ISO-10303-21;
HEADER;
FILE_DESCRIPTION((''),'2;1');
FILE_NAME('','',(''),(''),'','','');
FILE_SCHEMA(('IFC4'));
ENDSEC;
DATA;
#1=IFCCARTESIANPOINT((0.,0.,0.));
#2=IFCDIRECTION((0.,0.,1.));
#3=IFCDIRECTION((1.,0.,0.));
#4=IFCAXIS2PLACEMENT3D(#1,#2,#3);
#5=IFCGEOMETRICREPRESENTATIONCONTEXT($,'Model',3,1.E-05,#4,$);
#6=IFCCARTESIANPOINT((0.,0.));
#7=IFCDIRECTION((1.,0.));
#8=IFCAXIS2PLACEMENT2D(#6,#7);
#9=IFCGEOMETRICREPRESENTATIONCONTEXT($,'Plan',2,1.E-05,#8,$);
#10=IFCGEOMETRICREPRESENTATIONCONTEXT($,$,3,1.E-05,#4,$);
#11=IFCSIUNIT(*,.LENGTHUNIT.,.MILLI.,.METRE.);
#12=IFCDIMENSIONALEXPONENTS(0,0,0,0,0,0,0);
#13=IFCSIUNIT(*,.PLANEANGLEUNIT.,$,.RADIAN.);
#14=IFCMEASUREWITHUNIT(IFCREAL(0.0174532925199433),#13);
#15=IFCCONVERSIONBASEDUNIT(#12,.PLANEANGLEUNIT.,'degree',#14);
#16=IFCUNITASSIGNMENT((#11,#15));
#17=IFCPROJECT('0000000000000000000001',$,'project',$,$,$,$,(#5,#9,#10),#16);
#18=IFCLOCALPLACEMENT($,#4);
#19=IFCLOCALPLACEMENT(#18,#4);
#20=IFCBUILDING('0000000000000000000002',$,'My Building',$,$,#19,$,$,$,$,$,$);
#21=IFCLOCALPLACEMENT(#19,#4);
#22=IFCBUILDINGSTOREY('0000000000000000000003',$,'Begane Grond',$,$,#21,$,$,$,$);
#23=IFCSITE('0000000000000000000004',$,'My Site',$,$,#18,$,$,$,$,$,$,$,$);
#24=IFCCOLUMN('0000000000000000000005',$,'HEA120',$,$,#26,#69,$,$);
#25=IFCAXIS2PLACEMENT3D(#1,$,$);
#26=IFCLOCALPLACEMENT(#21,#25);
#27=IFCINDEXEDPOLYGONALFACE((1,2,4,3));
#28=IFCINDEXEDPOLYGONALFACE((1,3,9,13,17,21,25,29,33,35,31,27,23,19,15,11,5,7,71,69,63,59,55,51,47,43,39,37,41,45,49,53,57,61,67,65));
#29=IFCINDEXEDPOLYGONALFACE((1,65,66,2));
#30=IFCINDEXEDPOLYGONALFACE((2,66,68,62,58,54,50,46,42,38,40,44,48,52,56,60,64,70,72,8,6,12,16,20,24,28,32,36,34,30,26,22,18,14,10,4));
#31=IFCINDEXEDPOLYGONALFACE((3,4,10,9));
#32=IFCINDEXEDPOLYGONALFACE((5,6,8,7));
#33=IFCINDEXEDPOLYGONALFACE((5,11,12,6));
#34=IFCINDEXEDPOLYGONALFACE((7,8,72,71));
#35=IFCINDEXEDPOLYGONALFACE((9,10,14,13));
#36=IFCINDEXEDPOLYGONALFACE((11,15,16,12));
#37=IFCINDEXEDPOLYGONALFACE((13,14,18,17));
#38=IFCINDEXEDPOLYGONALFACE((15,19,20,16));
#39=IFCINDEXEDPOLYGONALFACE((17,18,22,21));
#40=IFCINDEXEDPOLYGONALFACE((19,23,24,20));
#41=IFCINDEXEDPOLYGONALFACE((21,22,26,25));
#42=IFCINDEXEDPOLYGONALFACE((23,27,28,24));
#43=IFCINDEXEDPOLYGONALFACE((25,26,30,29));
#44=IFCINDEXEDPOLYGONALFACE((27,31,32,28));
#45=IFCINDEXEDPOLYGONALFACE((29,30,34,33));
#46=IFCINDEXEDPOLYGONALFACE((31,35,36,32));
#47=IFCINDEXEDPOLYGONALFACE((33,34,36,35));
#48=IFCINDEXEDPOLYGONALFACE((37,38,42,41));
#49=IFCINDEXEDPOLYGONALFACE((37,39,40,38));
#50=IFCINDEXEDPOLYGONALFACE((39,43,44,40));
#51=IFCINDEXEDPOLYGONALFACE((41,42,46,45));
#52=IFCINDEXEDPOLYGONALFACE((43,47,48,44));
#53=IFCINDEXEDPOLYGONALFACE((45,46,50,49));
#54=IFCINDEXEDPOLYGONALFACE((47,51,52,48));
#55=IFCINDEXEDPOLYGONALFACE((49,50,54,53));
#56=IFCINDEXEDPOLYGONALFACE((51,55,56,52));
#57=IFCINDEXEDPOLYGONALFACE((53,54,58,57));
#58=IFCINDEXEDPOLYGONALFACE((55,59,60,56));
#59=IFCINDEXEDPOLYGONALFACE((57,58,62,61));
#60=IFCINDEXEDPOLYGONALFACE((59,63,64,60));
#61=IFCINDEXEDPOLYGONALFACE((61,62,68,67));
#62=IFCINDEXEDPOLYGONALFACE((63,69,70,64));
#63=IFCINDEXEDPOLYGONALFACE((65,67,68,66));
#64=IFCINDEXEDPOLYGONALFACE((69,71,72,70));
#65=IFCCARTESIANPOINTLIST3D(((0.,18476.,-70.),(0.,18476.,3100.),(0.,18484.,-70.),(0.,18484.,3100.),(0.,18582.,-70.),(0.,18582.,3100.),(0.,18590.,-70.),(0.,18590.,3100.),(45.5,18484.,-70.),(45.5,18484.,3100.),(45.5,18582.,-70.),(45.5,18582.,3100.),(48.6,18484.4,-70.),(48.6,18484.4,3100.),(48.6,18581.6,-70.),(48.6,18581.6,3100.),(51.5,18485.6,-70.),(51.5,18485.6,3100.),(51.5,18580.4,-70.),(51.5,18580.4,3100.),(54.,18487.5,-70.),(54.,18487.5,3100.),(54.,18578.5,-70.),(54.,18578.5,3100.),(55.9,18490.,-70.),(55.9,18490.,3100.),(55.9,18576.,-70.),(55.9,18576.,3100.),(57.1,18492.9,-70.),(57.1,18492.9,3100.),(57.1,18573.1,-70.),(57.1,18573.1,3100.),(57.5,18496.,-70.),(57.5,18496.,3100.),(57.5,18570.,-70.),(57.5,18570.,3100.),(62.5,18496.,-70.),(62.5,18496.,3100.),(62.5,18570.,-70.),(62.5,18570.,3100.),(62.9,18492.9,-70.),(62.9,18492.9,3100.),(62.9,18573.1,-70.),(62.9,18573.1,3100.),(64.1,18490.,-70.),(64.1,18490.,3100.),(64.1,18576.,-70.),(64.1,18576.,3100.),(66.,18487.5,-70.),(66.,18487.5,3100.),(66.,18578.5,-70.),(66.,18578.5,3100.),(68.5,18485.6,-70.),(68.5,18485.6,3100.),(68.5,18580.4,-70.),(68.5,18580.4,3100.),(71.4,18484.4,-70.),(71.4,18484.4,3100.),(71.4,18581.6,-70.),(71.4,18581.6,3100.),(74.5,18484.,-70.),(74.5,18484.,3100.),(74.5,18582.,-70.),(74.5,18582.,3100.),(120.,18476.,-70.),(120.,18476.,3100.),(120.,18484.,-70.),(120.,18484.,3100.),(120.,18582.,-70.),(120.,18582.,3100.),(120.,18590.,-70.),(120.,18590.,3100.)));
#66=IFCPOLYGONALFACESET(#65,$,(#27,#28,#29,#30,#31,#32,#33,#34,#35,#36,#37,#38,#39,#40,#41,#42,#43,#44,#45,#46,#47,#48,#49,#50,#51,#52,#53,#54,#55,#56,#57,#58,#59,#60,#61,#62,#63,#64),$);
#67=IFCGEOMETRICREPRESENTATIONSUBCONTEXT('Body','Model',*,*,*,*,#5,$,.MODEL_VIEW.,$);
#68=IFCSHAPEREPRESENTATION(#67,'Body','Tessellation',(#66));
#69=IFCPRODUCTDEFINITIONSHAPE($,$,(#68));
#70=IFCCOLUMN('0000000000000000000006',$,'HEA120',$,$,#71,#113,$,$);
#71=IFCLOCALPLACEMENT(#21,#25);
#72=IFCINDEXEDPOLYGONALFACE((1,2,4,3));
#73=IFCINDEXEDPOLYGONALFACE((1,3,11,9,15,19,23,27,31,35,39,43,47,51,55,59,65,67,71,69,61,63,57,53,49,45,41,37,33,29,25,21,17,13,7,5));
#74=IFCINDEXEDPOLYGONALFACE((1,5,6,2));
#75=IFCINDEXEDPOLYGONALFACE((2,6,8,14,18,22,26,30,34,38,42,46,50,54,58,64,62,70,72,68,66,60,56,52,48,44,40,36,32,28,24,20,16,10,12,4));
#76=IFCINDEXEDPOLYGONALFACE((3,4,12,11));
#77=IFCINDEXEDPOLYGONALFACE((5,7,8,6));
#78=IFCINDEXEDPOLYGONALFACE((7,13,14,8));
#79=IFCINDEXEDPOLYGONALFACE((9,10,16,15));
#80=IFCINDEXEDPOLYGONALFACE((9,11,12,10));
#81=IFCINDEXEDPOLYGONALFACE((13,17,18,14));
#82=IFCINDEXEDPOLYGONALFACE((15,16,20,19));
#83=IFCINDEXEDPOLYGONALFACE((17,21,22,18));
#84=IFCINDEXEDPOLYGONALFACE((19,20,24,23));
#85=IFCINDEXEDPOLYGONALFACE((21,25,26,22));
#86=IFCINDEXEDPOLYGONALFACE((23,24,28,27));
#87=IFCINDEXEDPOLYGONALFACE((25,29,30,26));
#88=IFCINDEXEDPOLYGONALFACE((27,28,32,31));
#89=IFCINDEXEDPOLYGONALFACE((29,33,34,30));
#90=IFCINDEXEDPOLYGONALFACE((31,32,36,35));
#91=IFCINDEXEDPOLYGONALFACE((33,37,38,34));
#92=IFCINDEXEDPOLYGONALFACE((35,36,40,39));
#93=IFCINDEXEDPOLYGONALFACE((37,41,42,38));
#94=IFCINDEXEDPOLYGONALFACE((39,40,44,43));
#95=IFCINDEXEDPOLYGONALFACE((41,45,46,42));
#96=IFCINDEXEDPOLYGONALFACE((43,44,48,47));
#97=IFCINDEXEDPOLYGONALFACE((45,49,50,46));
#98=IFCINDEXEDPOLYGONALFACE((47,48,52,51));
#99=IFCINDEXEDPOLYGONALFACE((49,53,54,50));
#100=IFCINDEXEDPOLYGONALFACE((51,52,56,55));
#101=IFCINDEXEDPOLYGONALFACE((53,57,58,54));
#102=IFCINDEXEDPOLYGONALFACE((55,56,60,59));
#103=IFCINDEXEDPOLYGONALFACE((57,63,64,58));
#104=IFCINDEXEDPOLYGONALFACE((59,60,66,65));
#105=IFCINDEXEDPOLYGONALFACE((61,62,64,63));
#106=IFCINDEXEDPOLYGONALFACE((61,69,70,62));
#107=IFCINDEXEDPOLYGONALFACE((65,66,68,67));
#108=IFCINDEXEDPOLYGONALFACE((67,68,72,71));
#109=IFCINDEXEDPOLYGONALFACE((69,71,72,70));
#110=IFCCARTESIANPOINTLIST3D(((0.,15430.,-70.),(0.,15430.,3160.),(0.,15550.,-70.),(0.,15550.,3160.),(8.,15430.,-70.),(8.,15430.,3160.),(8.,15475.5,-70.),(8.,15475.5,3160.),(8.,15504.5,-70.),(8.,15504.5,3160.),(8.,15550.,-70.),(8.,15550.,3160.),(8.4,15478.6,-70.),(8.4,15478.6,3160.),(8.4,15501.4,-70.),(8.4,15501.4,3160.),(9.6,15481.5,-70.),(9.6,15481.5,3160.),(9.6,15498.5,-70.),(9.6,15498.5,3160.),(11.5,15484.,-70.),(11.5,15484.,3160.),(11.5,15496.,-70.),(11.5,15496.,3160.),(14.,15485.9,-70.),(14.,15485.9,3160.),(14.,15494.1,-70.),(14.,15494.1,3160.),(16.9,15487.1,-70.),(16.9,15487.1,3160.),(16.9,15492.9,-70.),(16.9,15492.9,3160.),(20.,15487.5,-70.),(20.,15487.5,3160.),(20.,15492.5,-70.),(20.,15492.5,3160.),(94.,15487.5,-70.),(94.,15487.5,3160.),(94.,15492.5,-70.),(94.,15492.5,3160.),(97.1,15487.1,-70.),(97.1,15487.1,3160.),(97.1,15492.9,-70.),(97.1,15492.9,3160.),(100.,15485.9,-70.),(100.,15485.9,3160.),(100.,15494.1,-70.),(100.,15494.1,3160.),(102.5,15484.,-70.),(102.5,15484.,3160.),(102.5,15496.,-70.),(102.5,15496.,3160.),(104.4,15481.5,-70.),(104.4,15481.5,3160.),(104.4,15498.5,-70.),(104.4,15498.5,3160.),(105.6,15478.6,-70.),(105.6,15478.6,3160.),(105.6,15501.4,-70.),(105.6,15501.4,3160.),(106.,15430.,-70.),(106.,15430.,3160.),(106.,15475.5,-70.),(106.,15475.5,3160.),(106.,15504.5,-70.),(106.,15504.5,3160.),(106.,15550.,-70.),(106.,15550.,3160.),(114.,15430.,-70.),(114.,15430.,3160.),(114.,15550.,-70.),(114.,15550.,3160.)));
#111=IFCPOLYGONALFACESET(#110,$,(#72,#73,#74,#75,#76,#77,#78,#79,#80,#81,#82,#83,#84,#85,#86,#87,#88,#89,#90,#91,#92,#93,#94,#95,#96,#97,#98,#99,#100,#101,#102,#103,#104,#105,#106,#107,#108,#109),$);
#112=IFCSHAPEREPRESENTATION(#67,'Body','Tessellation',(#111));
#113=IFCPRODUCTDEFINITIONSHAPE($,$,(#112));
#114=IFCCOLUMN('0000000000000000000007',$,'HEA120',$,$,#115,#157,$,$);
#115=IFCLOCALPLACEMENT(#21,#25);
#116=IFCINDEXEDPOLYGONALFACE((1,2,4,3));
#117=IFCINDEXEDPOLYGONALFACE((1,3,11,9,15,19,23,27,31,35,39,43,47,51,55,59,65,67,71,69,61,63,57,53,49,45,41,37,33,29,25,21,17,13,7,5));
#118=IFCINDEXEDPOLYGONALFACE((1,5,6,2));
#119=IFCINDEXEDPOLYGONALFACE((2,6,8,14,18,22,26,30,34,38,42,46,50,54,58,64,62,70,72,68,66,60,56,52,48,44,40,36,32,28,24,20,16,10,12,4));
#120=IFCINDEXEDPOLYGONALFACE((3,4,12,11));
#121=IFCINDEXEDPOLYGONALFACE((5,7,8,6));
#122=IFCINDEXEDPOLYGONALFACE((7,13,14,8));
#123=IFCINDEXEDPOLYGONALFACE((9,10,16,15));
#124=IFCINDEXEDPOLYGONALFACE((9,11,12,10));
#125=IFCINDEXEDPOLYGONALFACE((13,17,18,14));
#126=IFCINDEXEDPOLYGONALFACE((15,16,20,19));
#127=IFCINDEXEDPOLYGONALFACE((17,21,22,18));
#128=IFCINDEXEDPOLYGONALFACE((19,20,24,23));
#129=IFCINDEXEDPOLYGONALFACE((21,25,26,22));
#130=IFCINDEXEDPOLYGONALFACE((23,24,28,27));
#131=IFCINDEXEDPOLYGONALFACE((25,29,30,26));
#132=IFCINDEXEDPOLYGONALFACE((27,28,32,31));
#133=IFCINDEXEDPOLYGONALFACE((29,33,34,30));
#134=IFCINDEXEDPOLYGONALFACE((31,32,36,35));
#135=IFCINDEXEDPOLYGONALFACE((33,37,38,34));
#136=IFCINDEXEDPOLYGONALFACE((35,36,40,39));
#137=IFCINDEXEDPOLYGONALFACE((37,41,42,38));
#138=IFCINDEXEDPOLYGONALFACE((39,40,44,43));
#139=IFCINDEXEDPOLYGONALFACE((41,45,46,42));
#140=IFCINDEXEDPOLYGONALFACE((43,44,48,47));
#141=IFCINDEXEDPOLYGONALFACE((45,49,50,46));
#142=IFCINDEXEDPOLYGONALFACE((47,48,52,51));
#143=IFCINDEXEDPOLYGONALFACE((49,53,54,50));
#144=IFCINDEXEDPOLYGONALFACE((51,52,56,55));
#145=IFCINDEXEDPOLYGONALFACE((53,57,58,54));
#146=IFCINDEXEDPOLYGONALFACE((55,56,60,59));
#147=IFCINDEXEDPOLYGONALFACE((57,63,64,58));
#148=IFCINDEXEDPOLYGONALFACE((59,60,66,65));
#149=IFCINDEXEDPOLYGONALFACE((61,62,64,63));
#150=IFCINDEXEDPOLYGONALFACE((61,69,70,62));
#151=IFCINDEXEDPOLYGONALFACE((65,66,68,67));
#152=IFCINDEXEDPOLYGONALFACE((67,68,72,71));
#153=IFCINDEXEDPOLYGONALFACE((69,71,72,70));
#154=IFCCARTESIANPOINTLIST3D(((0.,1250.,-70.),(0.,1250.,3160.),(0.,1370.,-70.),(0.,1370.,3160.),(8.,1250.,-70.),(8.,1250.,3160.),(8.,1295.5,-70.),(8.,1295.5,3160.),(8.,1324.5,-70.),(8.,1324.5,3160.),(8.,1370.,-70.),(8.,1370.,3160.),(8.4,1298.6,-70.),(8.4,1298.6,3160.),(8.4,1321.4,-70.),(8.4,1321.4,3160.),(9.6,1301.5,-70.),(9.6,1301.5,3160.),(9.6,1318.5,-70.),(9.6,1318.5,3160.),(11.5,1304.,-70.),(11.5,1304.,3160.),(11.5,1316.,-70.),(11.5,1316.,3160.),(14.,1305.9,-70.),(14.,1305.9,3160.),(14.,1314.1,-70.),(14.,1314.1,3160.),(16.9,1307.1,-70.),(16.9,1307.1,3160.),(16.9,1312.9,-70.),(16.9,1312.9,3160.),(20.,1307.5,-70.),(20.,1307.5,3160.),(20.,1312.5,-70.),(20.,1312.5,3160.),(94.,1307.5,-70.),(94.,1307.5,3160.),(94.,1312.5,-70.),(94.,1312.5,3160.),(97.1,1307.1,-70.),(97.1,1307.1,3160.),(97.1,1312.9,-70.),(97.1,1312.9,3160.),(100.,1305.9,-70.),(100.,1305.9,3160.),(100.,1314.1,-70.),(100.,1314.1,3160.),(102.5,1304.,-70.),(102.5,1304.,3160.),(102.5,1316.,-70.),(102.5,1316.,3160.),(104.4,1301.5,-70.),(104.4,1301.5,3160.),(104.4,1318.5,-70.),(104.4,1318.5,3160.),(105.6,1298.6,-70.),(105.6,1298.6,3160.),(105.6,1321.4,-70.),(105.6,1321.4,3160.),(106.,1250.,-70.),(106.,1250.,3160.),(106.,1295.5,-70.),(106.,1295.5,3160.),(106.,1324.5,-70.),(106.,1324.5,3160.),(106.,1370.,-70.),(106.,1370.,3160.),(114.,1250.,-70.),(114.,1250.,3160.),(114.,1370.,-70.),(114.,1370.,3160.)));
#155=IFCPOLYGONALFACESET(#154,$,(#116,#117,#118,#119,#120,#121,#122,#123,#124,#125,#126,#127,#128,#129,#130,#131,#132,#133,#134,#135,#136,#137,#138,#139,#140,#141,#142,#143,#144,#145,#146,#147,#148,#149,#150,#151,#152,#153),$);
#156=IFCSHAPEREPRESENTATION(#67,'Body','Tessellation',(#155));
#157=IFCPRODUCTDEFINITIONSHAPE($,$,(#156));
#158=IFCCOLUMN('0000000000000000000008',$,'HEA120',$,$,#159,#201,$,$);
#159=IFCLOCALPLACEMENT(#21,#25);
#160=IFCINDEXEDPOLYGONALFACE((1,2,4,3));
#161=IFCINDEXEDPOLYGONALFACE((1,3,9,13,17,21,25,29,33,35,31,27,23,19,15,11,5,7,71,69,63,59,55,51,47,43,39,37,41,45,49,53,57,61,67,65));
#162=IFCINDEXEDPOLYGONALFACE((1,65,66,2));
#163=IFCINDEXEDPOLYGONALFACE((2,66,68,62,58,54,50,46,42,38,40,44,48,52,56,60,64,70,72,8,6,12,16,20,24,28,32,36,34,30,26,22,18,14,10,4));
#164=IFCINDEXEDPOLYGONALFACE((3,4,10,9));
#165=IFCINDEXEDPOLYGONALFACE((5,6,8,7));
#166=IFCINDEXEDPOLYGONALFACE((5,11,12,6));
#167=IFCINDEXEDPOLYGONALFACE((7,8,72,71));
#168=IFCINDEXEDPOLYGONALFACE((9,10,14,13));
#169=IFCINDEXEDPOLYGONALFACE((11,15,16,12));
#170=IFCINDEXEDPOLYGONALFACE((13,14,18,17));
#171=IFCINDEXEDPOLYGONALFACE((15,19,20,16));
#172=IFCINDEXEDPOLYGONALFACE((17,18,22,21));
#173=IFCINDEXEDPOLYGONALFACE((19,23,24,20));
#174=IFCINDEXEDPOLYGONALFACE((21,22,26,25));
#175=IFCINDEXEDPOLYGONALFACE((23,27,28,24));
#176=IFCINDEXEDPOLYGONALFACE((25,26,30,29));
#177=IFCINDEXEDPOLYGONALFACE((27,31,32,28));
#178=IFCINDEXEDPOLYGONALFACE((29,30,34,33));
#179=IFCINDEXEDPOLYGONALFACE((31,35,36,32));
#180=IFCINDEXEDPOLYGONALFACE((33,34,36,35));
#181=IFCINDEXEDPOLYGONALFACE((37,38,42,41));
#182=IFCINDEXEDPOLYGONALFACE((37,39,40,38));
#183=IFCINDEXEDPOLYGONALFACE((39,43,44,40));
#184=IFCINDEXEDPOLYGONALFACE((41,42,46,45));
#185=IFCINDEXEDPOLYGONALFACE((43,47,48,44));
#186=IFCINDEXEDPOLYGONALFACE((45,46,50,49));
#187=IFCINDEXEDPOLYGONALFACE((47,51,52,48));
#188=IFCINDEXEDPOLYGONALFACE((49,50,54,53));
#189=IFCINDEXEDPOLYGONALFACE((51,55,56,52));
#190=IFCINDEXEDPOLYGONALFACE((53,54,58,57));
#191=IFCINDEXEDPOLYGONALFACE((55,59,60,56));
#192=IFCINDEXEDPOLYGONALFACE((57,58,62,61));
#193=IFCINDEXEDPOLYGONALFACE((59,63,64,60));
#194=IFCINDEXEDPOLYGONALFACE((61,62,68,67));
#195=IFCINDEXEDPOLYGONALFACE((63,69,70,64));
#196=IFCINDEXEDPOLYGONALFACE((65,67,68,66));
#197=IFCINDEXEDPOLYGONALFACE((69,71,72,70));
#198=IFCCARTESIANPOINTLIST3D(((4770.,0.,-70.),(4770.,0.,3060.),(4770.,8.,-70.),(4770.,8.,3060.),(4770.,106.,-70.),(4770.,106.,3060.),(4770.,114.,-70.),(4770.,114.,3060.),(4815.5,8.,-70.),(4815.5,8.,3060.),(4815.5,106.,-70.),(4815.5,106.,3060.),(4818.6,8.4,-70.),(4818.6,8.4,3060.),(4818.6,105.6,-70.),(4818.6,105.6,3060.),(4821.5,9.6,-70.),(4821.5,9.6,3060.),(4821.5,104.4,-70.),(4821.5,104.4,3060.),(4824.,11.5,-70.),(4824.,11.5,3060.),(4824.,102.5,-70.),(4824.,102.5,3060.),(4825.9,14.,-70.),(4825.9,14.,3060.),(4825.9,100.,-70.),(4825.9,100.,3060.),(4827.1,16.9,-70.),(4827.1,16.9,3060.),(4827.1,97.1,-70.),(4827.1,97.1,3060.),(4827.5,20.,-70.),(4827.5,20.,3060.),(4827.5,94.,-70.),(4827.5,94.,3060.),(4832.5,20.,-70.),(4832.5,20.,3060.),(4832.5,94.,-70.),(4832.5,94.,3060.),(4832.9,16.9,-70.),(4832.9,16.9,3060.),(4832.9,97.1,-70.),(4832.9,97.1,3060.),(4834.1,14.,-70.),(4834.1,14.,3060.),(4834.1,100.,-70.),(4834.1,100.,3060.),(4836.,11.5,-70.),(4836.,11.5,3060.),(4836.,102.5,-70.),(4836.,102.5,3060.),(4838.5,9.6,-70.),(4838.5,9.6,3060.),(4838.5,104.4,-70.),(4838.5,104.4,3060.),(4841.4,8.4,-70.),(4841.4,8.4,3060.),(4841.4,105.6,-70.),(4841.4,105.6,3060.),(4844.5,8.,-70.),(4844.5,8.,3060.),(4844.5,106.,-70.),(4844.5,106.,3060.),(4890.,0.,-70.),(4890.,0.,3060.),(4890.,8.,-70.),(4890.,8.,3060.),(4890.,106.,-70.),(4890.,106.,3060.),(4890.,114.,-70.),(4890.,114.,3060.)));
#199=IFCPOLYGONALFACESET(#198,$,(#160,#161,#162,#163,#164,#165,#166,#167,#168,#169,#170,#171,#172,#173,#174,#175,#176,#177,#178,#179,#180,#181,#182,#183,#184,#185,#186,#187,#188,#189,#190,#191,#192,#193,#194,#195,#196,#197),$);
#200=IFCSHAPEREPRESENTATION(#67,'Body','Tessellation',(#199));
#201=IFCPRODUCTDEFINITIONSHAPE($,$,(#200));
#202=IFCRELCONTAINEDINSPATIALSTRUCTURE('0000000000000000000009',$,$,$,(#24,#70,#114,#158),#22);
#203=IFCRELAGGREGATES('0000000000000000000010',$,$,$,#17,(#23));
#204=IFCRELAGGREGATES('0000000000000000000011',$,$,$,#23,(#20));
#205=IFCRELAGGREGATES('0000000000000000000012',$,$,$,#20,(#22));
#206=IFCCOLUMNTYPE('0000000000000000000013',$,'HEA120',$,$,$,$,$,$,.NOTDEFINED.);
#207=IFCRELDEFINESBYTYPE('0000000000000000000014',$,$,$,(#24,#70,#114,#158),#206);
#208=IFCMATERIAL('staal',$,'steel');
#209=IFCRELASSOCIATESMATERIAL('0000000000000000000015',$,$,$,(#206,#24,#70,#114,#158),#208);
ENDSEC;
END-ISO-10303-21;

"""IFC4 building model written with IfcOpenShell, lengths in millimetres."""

from ifc_helpers import new_model, entity, si_unit, converted_unit, frame, origin_with_axes, origin_2d_with_axis, place, context, subcontext, project, spatial, i_section, extrude, material, material_profile, profile_set, profile_usage, type_object, element, save


model = new_model("IFC4")

# Units and contexts
model_context = context("Model", 3, precision=1e-05, world=origin_with_axes())
plan_context = context("Plan", 2, precision=1e-05, world=origin_2d_with_axis())
context_of_model = context(None, 3, precision=1e-05, world=origin_with_axes())
body_context = subcontext(model_context, "Body", "Model", "MODEL_VIEW")
ifc_project = project(units=[si_unit("LENGTHUNIT", "METRE", prefix="MILLI"), converted_unit("PLANEANGLEUNIT", "degree", entity("IfcReal", 0.0174532925199433), si_unit("PLANEANGLEUNIT", "RADIAN"), dimensions=[0, 0, 0, 0, 0, 0, 0])], contexts=[model_context, plan_context, context_of_model])

# Site, building, storey
site_placement = place(None, origin_with_axes())
site = spatial("IfcSite", under=ifc_project, at=site_placement, Name="My Site")
building_placement = place(site_placement, origin_with_axes())
building = spatial("IfcBuilding", under=site, at=building_placement, Name="My Building")
storey_placement = place(building_placement, origin_with_axes())
storey = spatial("IfcBuildingStorey", under=building, at=storey_placement, Name="Begane Grond")

# Columns
ifc_material = material(Name="staal", Category="steel")
ifc_material_profile_1 = material_profile(ifc_material, i_section(OverallWidth=120.0, OverallDepth=114.0, WebThickness=5.0, FlangeThickness=8.0, FilletRadius=12.0))
ifc_profile_set_1 = profile_set([ifc_material_profile_1], Name="HEA120")
ifc_profile_usage_1 = profile_usage(ifc_profile_set_1, cardinal=8)
column_type_1 = type_object("IfcColumnType", Name="HEA120", PredefinedType="NOTDEFINED", material=ifc_profile_set_1)
column_1_placement = place(storey_placement, frame((60.0, 18590.0, -70.0), z_axis=(0.0, 0.0, 1.0), x_axis=(1.0, 0.0, 0.0)))
element("IfcColumn", 1, at=column_1_placement, inside=storey, type_object=column_type_1, material=ifc_profile_usage_1, Name="HEA120", context=body_context, shape_type="SweptSolid", body=[
    extrude(i_section(OverallWidth=120.0, OverallDepth=114.0, WebThickness=5.0, FlangeThickness=8.0, FilletRadius=12.0), frame((0.0, -57.0, 0.0), z_axis=(0.0, 0.0, 1.0), x_axis=(1.0, 0.0, 0.0)), (0.0, 0.0, 1.0), 3170.0),
])
ifc_profile_usage_2 = profile_usage(ifc_profile_set_1)
column_2_placement = place(storey_placement, frame((57.0, 15490.0, -70.0), z_axis=(0.0, 0.0, 1.0), x_axis=(0.0, 1.0, 0.0)))
element("IfcColumn", 2, at=column_2_placement, inside=storey, type_object=column_type_1, material=ifc_profile_usage_2, Name="HEA120", context=body_context, shape_type="SweptSolid", body=[
    extrude(i_section(OverallWidth=120.0, OverallDepth=114.0, WebThickness=5.0, FlangeThickness=8.0, FilletRadius=12.0), origin_with_axes(), (0.0, 0.0, 1.0), 3230.0),
])
ifc_profile_usage_3 = profile_usage(ifc_profile_set_1)
column_3_placement = place(storey_placement, frame((57.0, 1310.0, -70.0), z_axis=(0.0, 0.0, 1.0), x_axis=(0.0, 1.0, 0.0)))
element("IfcColumn", 3, at=column_3_placement, inside=storey, type_object=column_type_1, material=ifc_profile_usage_3, Name="HEA120", context=body_context, shape_type="SweptSolid", body=[
    extrude(i_section(OverallWidth=120.0, OverallDepth=114.0, WebThickness=5.0, FlangeThickness=8.0, FilletRadius=12.0), origin_with_axes(), (0.0, 0.0, 1.0), 3230.0),
])
ifc_profile_usage_4 = profile_usage(ifc_profile_set_1)
column_4_placement = place(storey_placement, frame((4830.0, 57.0, -70.0), z_axis=(0.0, 0.0, 1.0), x_axis=(-1.0, 0.0, 0.0)))
element("IfcColumn", 4, at=column_4_placement, inside=storey, type_object=column_type_1, material=ifc_profile_usage_4, Name="HEA120", context=body_context, shape_type="SweptSolid", body=[
    extrude(i_section(OverallWidth=120.0, OverallDepth=114.0, WebThickness=5.0, FlangeThickness=8.0, FilletRadius=12.0), origin_with_axes(), (0.0, 0.0, 1.0), 3130.0),
])

save(model, "model.ifc")
